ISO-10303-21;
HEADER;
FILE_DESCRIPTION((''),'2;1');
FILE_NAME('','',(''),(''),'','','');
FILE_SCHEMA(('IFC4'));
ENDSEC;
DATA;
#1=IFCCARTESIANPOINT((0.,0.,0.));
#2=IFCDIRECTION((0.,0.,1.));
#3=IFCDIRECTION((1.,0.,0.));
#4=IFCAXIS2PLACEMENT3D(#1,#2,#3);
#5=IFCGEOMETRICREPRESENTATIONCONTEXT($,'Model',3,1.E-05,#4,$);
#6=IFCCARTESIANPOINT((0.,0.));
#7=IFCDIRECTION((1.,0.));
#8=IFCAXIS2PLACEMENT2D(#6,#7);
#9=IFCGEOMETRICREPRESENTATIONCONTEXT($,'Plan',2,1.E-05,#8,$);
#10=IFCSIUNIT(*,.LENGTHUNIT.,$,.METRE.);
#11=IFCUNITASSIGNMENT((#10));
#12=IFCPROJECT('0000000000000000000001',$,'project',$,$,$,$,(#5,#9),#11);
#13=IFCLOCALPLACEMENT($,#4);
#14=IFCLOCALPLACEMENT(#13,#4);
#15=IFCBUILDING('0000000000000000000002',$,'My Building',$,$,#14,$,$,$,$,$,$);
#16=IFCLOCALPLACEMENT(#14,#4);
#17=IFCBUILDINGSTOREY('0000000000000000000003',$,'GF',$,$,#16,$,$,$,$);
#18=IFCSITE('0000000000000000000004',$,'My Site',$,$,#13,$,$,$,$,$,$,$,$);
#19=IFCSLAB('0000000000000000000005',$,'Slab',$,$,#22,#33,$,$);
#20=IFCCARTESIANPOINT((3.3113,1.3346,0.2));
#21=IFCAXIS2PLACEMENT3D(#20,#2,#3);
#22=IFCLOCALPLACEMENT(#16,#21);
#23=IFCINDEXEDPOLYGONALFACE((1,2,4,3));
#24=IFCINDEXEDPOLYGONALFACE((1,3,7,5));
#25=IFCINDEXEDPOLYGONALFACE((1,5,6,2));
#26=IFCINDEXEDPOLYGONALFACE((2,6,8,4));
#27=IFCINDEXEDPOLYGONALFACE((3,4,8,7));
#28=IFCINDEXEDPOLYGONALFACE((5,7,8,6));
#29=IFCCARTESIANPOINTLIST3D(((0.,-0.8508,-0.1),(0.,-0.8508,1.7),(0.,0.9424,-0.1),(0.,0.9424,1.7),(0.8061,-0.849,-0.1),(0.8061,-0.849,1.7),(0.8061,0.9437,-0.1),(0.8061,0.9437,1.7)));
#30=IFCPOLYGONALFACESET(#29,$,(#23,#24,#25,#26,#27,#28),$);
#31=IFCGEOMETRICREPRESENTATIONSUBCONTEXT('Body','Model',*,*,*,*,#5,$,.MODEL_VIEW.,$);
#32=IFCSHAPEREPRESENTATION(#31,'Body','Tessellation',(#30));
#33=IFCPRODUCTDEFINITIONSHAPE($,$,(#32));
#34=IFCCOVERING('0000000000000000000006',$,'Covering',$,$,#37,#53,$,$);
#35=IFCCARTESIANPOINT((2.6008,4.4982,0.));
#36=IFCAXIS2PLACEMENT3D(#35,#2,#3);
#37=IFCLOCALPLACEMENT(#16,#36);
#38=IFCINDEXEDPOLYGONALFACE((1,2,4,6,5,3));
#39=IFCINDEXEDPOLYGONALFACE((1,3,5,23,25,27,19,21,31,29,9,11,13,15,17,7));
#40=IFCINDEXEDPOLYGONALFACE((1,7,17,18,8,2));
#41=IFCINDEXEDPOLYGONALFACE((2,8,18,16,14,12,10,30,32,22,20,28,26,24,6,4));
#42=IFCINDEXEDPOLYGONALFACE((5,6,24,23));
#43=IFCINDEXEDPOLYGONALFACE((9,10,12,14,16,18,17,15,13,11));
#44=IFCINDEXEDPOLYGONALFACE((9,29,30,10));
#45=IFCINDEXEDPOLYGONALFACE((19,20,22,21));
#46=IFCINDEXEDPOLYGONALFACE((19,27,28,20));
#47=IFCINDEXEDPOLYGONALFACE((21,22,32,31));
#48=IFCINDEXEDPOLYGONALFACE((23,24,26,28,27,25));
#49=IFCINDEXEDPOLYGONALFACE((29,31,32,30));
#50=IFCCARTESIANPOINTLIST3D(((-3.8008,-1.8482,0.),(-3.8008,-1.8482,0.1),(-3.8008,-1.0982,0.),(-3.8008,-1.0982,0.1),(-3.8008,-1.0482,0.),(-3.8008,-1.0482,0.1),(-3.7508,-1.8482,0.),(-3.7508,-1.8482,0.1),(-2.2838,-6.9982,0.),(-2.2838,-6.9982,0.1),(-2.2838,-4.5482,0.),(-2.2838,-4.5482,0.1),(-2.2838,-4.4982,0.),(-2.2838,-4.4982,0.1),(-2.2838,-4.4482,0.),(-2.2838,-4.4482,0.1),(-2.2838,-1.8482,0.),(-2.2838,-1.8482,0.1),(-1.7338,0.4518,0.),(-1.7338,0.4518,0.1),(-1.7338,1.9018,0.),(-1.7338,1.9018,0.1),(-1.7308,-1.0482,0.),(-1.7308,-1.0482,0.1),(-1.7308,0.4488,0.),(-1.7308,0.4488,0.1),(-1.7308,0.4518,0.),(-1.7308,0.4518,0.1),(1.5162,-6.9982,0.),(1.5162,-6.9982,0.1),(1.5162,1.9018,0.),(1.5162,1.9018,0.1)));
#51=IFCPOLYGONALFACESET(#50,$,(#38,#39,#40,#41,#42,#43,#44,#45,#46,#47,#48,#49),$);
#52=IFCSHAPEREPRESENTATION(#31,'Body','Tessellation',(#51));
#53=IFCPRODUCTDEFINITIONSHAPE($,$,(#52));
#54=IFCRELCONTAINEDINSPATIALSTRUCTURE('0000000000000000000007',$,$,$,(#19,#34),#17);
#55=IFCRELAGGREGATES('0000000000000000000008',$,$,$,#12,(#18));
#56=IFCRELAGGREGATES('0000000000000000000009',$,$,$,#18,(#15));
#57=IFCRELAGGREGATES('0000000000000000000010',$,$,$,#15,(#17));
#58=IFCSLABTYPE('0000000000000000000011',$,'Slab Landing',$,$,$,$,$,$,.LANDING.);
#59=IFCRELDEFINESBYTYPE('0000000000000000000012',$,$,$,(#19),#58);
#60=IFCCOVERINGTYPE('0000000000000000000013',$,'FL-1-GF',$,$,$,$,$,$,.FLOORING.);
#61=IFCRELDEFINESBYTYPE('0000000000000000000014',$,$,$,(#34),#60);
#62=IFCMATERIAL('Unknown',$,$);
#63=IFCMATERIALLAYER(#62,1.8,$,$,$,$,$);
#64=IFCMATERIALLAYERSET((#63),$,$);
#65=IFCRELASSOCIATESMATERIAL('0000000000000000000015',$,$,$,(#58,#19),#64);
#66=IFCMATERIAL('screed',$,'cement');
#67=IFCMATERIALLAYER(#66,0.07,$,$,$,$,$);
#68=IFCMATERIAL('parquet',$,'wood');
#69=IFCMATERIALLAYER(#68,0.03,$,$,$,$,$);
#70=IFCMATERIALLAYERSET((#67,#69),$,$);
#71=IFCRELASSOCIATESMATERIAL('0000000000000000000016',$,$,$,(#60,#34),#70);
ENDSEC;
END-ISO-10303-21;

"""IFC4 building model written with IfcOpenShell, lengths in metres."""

from ifc_helpers import new_model, si_unit, frame, origin_with_axes, origin_2d_with_axis, place, context, subcontext, project, spatial, line, indexed_curve, outline, extrude, material, layer, layer_set, layer_usage, type_object, element, save


model = new_model("IFC4")

# Units and contexts
model_context = context("Model", 3, precision=1e-05, world=origin_with_axes())
plan_context = context("Plan", 2, precision=1e-05, world=origin_2d_with_axis())
body_context_1 = subcontext(model_context, "Body", "Model", "MODEL_VIEW")
ifc_project = project(units=[si_unit("LENGTHUNIT", "METRE")], contexts=[model_context, plan_context])

# Site, building, storey
site_placement = place(None, origin_with_axes())
site = spatial("IfcSite", under=ifc_project, at=site_placement, Name="My Site")
building_placement = place(site_placement, origin_with_axes())
building = spatial("IfcBuilding", under=site, at=building_placement, Name="My Building")
storey_placement = place(building_placement, origin_with_axes())
storey = spatial("IfcBuildingStorey", under=building, at=storey_placement, Name="GF")

# Slab
ifc_material_1 = material(Name="Unknown")
ifc_layer_1 = layer(ifc_material_1, 1.8)
ifc_layer_set_1 = layer_set([ifc_layer_1])
ifc_layer_usage_1 = layer_usage(ifc_layer_set_1, "AXIS3", "POSITIVE", -0.1)
slab_type_1 = type_object("IfcSlabType", Name="Slab Landing", PredefinedType="LANDING", material=ifc_layer_set_1)
slab_1_placement = place(storey_placement, frame((3.3113, 1.3346, 0.2), z_axis=(0.0, 0.0, 1.0), x_axis=(1.0, 0.0, 0.0)))
element("IfcSlab", 1, at=slab_1_placement, inside=storey, type_object=slab_type_1, material=ifc_layer_usage_1, Name="Slab", context=body_context_1, shape_type="SweptSolid", body=[
    extrude(outline(indexed_curve([(0.0, 0.9424), (0.0, -0.8508), (0.8061, -0.849), (0.8061, 0.9437), (0.0, 0.9424)])), frame((0.0, 0.0, -0.1), z_axis=(0.0, 0.0, 1.0), x_axis=(1.0, 0.0, 0.0)), (0.0, 0.0, 1.0), 1.8),
])

# Covering
ifc_material_2 = material(Name="screed", Category="cement")
ifc_layer_2 = layer(ifc_material_2, 0.07)
ifc_material_3 = material(Name="parquet", Category="wood")
ifc_layer_3 = layer(ifc_material_3, 0.03)
ifc_layer_set_2 = layer_set([ifc_layer_2, ifc_layer_3])
ifc_layer_usage_2 = layer_usage(ifc_layer_set_2, "AXIS3", "POSITIVE", 0.0)
covering_type = type_object("IfcCoveringType", Name="FL-1-GF", PredefinedType="FLOORING", material=ifc_layer_set_2)
covering_placement = place(storey_placement, frame((2.6008, 4.4982, 0.0), z_axis=(0.0, 0.0, 1.0), x_axis=(1.0, 0.0, 0.0)))
element("IfcCovering", 2, at=covering_placement, inside=storey, type_object=covering_type, material=ifc_layer_usage_2, Name="Covering", context=body_context_1, shape_type="SweptSolid", body=[
    extrude(outline(indexed_curve([(-1.7338, 1.9018), (1.5162, 1.9018), (1.5162, -6.9982), (-2.2838, -6.9982), (-2.2838, -4.5482), (-2.2838, -4.4982), (-2.2838, -4.4482), (-2.2838, -1.8482), (-3.7508, -1.8482), (-3.8008, -1.8482), (-3.8008, -1.0982), (-3.8008, -1.0482), (-1.7308, -1.0482), (-1.7308, 0.4488), (-1.7308, 0.4518), (-1.7338, 0.4518)], segments=[line(1, 2, 3, 4, 5, 6, 7, 8, 9, 10, 11, 12, 13, 14, 15, 16, 1)])), origin_with_axes(), (0.0, 0.0, 1.0), 0.1),
])

save(model, "model.ifc")
